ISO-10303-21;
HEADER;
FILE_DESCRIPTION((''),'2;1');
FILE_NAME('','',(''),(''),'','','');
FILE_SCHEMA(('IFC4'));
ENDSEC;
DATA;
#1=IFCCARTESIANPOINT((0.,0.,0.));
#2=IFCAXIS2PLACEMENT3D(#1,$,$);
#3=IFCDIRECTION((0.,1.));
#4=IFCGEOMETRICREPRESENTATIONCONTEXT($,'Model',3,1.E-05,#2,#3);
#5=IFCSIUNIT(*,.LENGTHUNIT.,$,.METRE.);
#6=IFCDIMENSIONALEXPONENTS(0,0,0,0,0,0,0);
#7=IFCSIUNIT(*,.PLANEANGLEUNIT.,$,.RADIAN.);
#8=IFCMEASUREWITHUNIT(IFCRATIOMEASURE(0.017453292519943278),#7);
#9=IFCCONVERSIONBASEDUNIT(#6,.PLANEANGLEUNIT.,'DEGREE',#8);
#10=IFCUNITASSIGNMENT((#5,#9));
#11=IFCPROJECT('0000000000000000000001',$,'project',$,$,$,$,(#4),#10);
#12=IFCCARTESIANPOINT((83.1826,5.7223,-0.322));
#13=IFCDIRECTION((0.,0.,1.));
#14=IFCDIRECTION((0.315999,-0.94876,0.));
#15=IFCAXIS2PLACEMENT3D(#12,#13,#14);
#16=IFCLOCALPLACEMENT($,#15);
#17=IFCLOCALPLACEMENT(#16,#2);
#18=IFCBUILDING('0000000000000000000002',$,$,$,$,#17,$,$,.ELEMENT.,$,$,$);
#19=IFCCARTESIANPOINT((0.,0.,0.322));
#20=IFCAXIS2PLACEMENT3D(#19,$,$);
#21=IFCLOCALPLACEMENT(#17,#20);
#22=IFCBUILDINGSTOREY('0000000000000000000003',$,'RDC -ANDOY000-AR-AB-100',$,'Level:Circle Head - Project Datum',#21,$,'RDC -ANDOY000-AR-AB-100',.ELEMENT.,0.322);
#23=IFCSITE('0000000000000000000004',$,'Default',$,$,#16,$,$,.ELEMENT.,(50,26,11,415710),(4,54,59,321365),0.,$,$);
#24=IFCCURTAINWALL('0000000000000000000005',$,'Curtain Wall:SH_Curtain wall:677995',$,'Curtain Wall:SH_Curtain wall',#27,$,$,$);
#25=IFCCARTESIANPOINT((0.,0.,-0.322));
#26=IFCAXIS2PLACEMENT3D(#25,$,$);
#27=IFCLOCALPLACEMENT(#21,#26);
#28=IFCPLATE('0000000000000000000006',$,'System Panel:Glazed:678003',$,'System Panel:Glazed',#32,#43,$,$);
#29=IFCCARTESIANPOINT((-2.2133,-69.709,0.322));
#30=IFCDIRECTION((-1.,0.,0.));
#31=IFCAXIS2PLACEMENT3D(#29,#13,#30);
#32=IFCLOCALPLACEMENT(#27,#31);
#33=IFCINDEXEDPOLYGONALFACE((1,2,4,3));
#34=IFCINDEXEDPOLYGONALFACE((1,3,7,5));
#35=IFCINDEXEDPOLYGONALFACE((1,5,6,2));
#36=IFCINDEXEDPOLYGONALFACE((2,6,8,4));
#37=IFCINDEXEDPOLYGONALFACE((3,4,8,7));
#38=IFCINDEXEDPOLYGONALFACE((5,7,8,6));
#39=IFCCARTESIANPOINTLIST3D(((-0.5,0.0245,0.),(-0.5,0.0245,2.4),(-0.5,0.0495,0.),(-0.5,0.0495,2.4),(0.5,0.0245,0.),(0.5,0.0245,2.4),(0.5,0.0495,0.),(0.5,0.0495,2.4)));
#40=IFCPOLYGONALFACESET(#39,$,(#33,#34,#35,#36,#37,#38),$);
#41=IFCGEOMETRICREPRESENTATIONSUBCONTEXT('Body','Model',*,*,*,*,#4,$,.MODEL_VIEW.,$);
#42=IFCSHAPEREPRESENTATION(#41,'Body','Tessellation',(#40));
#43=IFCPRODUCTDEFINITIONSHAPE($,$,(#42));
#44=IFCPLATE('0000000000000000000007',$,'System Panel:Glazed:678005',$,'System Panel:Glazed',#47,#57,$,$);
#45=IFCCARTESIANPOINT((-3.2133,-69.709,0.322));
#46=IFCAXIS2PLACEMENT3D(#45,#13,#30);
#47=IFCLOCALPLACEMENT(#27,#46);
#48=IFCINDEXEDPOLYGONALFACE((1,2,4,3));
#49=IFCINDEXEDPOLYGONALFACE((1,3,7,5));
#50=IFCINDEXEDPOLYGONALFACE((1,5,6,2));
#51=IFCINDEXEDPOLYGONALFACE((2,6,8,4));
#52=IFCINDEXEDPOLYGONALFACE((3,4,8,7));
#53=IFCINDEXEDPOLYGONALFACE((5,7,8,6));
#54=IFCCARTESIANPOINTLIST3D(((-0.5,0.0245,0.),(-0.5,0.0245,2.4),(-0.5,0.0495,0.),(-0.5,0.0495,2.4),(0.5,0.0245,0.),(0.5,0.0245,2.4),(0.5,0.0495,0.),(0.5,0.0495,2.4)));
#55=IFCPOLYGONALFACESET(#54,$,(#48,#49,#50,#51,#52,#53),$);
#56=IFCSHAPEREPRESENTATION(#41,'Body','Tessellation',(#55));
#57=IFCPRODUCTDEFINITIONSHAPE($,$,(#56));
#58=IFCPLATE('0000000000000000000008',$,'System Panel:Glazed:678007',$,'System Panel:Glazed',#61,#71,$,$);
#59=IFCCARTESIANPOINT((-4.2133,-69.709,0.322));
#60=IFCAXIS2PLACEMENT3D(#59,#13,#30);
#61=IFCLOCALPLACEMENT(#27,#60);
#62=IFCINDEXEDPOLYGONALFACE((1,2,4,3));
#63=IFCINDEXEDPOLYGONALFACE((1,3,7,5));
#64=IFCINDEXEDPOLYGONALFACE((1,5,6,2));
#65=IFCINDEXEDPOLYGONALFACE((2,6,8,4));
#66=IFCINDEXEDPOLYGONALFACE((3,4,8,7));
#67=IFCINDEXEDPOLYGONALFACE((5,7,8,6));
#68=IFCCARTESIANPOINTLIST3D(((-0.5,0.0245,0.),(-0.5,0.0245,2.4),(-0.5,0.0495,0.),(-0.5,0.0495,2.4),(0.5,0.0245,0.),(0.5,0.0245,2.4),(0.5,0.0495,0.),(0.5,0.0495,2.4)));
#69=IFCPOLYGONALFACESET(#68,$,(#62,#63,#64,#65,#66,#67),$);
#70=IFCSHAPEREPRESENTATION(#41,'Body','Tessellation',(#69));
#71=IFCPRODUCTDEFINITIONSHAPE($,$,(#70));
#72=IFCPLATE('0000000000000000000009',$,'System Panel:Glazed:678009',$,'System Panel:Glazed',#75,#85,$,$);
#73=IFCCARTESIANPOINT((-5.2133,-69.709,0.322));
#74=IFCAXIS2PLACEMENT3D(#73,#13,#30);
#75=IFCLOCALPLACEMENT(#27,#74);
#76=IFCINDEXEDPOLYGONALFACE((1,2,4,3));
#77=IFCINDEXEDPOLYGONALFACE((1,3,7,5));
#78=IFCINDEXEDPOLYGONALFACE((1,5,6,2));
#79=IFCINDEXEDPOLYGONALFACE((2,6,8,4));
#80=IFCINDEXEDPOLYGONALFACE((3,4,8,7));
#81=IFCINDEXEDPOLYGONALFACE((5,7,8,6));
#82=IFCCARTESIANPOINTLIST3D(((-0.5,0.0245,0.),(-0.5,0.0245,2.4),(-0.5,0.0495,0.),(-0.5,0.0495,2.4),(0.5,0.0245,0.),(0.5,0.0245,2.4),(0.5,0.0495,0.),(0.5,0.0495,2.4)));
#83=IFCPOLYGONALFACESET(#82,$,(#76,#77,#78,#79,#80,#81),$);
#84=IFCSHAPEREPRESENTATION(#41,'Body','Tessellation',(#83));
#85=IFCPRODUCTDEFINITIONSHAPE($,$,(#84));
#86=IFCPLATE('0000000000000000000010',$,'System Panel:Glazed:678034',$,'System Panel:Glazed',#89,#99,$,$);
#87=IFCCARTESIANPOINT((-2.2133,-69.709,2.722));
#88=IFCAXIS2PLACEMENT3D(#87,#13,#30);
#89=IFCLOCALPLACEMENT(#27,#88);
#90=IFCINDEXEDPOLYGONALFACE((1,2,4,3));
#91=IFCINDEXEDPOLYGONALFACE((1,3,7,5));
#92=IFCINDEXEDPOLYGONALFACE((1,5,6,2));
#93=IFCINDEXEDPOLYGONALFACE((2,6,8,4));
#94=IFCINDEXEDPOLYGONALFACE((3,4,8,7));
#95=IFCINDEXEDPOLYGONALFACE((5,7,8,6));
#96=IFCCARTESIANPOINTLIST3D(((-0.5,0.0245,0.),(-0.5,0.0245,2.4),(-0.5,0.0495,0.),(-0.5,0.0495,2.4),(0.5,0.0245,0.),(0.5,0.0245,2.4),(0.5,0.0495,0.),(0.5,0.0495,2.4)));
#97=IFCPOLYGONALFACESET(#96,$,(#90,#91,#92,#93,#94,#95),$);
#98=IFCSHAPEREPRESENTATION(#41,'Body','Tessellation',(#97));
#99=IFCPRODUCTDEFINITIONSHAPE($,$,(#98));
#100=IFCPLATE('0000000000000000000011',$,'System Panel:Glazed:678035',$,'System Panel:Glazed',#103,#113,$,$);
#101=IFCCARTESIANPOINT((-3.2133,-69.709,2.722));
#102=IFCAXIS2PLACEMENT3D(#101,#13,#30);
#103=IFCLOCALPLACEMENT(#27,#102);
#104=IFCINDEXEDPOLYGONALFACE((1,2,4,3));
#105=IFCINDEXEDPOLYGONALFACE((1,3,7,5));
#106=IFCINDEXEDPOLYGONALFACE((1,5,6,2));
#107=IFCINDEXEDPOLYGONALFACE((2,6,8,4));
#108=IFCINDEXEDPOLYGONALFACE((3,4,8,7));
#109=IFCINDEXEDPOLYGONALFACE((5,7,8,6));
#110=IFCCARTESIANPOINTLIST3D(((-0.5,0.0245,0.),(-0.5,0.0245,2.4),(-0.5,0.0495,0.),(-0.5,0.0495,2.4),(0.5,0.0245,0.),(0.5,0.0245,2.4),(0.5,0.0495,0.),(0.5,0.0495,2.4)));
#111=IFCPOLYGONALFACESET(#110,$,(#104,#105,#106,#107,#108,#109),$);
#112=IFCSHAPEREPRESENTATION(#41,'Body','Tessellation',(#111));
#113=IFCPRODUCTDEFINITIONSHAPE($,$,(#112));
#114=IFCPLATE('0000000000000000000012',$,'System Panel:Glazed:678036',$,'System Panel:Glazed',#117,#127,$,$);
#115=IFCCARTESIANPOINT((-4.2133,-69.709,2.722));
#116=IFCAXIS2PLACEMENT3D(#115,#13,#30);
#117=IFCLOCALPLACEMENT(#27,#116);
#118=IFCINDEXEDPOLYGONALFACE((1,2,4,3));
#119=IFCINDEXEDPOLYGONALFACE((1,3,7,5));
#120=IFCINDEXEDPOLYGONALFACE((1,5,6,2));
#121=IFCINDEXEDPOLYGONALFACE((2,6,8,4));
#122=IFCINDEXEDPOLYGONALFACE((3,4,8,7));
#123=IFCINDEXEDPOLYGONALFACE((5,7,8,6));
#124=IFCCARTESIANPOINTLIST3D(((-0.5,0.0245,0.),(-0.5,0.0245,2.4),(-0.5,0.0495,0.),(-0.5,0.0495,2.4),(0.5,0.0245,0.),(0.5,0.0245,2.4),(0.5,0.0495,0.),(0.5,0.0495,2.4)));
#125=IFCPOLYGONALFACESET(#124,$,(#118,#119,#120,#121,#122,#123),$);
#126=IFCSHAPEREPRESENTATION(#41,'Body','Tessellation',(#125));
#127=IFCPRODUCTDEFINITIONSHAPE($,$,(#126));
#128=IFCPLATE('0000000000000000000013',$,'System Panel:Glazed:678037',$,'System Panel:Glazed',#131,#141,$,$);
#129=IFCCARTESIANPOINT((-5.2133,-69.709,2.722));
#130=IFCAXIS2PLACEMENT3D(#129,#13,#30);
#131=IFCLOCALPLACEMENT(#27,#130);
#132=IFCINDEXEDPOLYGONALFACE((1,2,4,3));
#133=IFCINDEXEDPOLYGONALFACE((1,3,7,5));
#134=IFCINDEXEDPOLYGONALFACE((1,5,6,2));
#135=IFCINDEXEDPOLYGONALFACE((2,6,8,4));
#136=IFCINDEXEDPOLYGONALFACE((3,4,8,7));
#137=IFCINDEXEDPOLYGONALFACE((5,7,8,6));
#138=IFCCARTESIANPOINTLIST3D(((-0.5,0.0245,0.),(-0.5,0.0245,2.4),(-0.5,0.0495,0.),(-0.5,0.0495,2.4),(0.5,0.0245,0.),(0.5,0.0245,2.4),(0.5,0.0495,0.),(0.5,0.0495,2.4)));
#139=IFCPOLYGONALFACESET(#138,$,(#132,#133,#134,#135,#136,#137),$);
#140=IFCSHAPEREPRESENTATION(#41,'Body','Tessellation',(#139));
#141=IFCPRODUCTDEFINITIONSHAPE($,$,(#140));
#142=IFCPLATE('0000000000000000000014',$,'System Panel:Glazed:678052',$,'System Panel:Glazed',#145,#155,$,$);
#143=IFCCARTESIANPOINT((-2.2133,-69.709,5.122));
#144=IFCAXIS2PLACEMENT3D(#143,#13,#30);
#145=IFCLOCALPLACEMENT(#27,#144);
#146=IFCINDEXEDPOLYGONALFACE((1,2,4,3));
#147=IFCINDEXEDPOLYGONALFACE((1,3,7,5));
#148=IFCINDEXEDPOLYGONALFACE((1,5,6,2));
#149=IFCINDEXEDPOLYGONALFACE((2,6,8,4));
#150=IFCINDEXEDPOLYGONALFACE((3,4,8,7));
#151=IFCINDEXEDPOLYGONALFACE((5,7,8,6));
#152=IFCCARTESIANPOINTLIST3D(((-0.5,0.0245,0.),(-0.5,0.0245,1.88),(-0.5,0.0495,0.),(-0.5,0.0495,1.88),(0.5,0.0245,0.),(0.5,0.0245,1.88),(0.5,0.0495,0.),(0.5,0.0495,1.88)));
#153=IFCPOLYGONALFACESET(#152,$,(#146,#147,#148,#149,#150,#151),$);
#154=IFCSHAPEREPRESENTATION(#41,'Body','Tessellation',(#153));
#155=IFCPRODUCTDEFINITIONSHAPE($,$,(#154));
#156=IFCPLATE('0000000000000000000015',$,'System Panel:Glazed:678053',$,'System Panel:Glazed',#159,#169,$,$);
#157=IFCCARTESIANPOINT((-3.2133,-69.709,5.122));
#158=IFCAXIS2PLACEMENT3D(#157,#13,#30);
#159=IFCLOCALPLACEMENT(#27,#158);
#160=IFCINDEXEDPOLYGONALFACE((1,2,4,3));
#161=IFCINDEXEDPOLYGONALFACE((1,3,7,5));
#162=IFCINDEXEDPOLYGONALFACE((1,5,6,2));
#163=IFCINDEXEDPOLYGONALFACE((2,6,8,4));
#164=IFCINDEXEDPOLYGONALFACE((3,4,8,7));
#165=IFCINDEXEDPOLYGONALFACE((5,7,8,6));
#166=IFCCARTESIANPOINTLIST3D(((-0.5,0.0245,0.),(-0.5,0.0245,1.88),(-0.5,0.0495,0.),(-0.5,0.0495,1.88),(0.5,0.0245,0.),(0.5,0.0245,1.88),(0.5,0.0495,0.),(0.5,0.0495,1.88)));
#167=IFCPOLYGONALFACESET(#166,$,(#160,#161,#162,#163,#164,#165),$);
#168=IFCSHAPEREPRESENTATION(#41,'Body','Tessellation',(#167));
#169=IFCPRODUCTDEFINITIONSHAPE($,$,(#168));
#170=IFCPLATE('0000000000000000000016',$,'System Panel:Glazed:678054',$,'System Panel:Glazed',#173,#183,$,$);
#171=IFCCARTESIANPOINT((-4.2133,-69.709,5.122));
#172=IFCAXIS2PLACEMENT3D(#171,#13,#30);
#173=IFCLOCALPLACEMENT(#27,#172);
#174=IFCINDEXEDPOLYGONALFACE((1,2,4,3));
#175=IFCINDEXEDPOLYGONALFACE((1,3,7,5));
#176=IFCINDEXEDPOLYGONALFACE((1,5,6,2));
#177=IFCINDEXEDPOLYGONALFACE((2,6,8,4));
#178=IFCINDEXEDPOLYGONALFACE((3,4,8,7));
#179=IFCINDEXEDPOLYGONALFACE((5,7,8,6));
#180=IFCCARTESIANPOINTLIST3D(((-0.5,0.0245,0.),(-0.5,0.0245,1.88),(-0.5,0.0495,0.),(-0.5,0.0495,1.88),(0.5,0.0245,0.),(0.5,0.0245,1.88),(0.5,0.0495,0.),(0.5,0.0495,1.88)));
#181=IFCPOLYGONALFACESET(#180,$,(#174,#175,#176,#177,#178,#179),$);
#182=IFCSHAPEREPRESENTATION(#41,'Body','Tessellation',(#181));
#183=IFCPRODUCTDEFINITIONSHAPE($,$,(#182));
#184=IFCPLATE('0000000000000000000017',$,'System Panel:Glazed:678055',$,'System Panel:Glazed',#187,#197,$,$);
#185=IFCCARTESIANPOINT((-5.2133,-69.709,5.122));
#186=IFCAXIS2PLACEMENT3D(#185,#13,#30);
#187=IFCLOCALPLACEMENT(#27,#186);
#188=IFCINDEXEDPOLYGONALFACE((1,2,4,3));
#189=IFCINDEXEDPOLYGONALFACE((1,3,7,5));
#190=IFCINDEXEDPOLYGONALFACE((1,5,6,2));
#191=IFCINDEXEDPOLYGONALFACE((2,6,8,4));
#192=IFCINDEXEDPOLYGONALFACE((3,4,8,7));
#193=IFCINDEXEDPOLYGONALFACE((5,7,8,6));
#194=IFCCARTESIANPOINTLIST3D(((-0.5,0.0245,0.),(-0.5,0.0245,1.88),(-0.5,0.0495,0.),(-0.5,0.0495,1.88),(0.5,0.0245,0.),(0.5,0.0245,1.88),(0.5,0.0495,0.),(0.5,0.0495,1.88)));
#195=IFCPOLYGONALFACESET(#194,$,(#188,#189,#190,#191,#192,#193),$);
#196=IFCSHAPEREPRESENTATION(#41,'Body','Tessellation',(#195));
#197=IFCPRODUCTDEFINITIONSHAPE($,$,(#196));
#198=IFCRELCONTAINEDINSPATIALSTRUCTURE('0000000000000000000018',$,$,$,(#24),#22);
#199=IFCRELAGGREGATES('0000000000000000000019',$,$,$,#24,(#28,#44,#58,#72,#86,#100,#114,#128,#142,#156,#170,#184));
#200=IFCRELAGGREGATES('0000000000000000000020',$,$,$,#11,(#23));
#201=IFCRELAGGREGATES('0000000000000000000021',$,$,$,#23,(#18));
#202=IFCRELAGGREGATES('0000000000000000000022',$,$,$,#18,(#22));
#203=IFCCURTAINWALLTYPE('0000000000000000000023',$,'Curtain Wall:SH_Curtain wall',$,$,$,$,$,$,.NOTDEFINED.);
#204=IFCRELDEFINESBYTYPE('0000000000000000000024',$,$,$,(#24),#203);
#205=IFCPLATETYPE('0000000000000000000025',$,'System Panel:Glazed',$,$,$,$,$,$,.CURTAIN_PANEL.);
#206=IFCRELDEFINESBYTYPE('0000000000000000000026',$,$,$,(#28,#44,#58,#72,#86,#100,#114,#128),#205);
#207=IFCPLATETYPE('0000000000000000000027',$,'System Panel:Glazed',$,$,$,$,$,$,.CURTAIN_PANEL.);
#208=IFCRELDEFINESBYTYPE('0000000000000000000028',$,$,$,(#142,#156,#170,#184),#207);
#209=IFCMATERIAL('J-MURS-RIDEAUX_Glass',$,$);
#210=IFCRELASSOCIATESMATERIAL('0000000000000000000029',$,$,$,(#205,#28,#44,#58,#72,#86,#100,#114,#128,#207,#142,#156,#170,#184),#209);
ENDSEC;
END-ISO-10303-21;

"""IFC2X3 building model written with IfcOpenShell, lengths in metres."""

from ifc_helpers import new_model, entity, si_unit, converted_unit, direction, frame, frame_2d, origin, origin_2d_with_axis, place, context, subcontext, project, spatial, rectangle, extrude, source, transform, mapped, material, type_object, type_shapes, element, aggregate, save


model = new_model("IFC2X3")

# Units and contexts
model_context = context("Model", 3, precision=1e-05, world=origin(), true_north=direction((0.0, 1.0)))
body_context = subcontext(model_context, "Body", "Model", "MODEL_VIEW")
ifc_project = project(units=[si_unit("LENGTHUNIT", "METRE"), converted_unit("PLANEANGLEUNIT", "DEGREE", entity("IfcRatioMeasure", 0.017453292519943278), si_unit("PLANEANGLEUNIT", "RADIAN"), dimensions=[0, 0, 0, 0, 0, 0, 0])], contexts=[model_context])

# Site, building, storey
site_placement = place(None, frame((83.1826, 5.7223, -0.322), z_axis=(0.0, 0.0, 1.0), x_axis=(0.315999, -0.94876, 0.0)))
site = spatial("IfcSite", under=ifc_project, at=site_placement, Name="Default", CompositionType="ELEMENT", RefLatitude=(50, 26, 11, 415710), RefLongitude=(4, 54, 59, 321365), RefElevation=0.0)
building_placement = place(site_placement, origin())
building = spatial("IfcBuilding", under=site, at=building_placement, CompositionType="ELEMENT")
storey_placement = place(building_placement, frame((0.0, 0.0, 0.322)))
storey = spatial("IfcBuildingStorey", under=building, at=storey_placement, Name="RDC -ANDOY000-AR-AB-100", ObjectType="Level:Circle Head - Project Datum", LongName="RDC -ANDOY000-AR-AB-100", CompositionType="ELEMENT", Elevation=0.322)

# Curtain wall, plates
curtain_wall_type = type_object("IfcCurtainWallType", Name="Curtain Wall:SH_Curtain wall", PredefinedType="NOTDEFINED")
curtain_wall_placement = place(storey_placement, frame((0.0, 0.0, -0.322)))
curtain_wall = element("IfcCurtainWall", 1, at=curtain_wall_placement, inside=storey, type_object=curtain_wall_type, Name="Curtain Wall:SH_Curtain wall:677995", ObjectType="Curtain Wall:SH_Curtain wall")
ifc_material_1 = material(Name="J-MURS-RIDEAUX_Glass")
plate_type_1 = type_object("IfcPlateType", Name="System Panel:Glazed", PredefinedType="CURTAIN_PANEL", material=ifc_material_1)
shared_shape_1 = source(origin(), body_context, "Body", "SweptSolid", [
    extrude(rectangle(XDim=0.025, YDim=1.0, at=frame_2d((0.0, 0.0), x_axis=(1.0, 0.0))), frame((0.0, 0.037, 0.0), z_axis=(0.0, 0.0, 1.0), x_axis=(0.0, 1.0, 0.0)), (0.0, 0.0, 1.0), 2.4),
])
type_shapes(plate_type_1, [shared_shape_1])
plate_1_placement = place(curtain_wall_placement, frame((-2.2133, -69.709, 0.322), z_axis=(0.0, 0.0, 1.0), x_axis=(-1.0, 0.0, 0.0)))
plate_1 = element("IfcPlate", 2, at=plate_1_placement, type_object=plate_type_1, material=ifc_material_1, Name="System Panel:Glazed:678003", ObjectType="System Panel:Glazed", context=body_context, shape_type="MappedRepresentation", body=[
    mapped(shared_shape_1, transform((0.0, 0.0, 0.0), scale=1.0)),
])
plate_2_placement = place(curtain_wall_placement, frame((-3.2133, -69.709, 0.322), z_axis=(0.0, 0.0, 1.0), x_axis=(-1.0, 0.0, 0.0)))
plate_2 = element("IfcPlate", 3, at=plate_2_placement, type_object=plate_type_1, material=ifc_material_1, Name="System Panel:Glazed:678005", ObjectType="System Panel:Glazed", context=body_context, shape_type="MappedRepresentation", body=[
    mapped(shared_shape_1, transform((0.0, 0.0, 0.0), scale=1.0)),
])
plate_3_placement = place(curtain_wall_placement, frame((-4.2133, -69.709, 0.322), z_axis=(0.0, 0.0, 1.0), x_axis=(-1.0, 0.0, 0.0)))
plate_3 = element("IfcPlate", 4, at=plate_3_placement, type_object=plate_type_1, material=ifc_material_1, Name="System Panel:Glazed:678007", ObjectType="System Panel:Glazed", context=body_context, shape_type="MappedRepresentation", body=[
    mapped(shared_shape_1, transform((0.0, 0.0, 0.0), scale=1.0)),
])
plate_4_placement = place(curtain_wall_placement, frame((-5.2133, -69.709, 0.322), z_axis=(0.0, 0.0, 1.0), x_axis=(-1.0, 0.0, 0.0)))
plate_4 = element("IfcPlate", 5, at=plate_4_placement, type_object=plate_type_1, material=ifc_material_1, Name="System Panel:Glazed:678009", ObjectType="System Panel:Glazed", context=body_context, shape_type="MappedRepresentation", body=[
    mapped(shared_shape_1, transform((0.0, 0.0, 0.0), scale=1.0)),
])
plate_5_placement = place(curtain_wall_placement, frame((-2.2133, -69.709, 2.722), z_axis=(0.0, 0.0, 1.0), x_axis=(-1.0, 0.0, 0.0)))
plate_5 = element("IfcPlate", 6, at=plate_5_placement, type_object=plate_type_1, material=ifc_material_1, Name="System Panel:Glazed:678034", ObjectType="System Panel:Glazed", context=body_context, shape_type="MappedRepresentation", body=[
    mapped(shared_shape_1, transform((0.0, 0.0, 0.0), scale=1.0)),
])
plate_6_placement = place(curtain_wall_placement, frame((-3.2133, -69.709, 2.722), z_axis=(0.0, 0.0, 1.0), x_axis=(-1.0, 0.0, 0.0)))
plate_6 = element("IfcPlate", 7, at=plate_6_placement, type_object=plate_type_1, material=ifc_material_1, Name="System Panel:Glazed:678035", ObjectType="System Panel:Glazed", context=body_context, shape_type="MappedRepresentation", body=[
    mapped(shared_shape_1, transform((0.0, 0.0, 0.0), scale=1.0)),
])
plate_7_placement = place(curtain_wall_placement, frame((-4.2133, -69.709, 2.722), z_axis=(0.0, 0.0, 1.0), x_axis=(-1.0, 0.0, 0.0)))
plate_7 = element("IfcPlate", 8, at=plate_7_placement, type_object=plate_type_1, material=ifc_material_1, Name="System Panel:Glazed:678036", ObjectType="System Panel:Glazed", context=body_context, shape_type="MappedRepresentation", body=[
    mapped(shared_shape_1, transform((0.0, 0.0, 0.0), scale=1.0)),
])
plate_8_placement = place(curtain_wall_placement, frame((-5.2133, -69.709, 2.722), z_axis=(0.0, 0.0, 1.0), x_axis=(-1.0, 0.0, 0.0)))
plate_8 = element("IfcPlate", 9, at=plate_8_placement, type_object=plate_type_1, material=ifc_material_1, Name="System Panel:Glazed:678037", ObjectType="System Panel:Glazed", context=body_context, shape_type="MappedRepresentation", body=[
    mapped(shared_shape_1, transform((0.0, 0.0, 0.0), scale=1.0)),
])
plate_type_2 = type_object("IfcPlateType", Name="System Panel:Glazed", PredefinedType="CURTAIN_PANEL", material=ifc_material_1)
shared_shape_2 = source(origin(), body_context, "Body", "SweptSolid", [
    extrude(rectangle(XDim=0.025, YDim=1.0, at=origin_2d_with_axis()), frame((0.0, 0.037, 0.0), z_axis=(0.0, 0.0, 1.0), x_axis=(0.0, 1.0, 0.0)), (0.0, 0.0, 1.0), 1.88),
])
type_shapes(plate_type_2, [shared_shape_2])
plate_9_placement = place(curtain_wall_placement, frame((-2.2133, -69.709, 5.122), z_axis=(0.0, 0.0, 1.0), x_axis=(-1.0, 0.0, 0.0)))
plate_9 = element("IfcPlate", 10, at=plate_9_placement, type_object=plate_type_2, material=ifc_material_1, Name="System Panel:Glazed:678052", ObjectType="System Panel:Glazed", context=body_context, shape_type="MappedRepresentation", body=[
    mapped(shared_shape_2, transform((0.0, 0.0, 0.0), scale=1.0)),
])
plate_10_placement = place(curtain_wall_placement, frame((-3.2133, -69.709, 5.122), z_axis=(0.0, 0.0, 1.0), x_axis=(-1.0, 0.0, 0.0)))
plate_10 = element("IfcPlate", 11, at=plate_10_placement, type_object=plate_type_2, material=ifc_material_1, Name="System Panel:Glazed:678053", ObjectType="System Panel:Glazed", context=body_context, shape_type="MappedRepresentation", body=[
    mapped(shared_shape_2, transform((0.0, 0.0, 0.0), scale=1.0)),
])
plate_11_placement = place(curtain_wall_placement, frame((-4.2133, -69.709, 5.122), z_axis=(0.0, 0.0, 1.0), x_axis=(-1.0, 0.0, 0.0)))
plate_11 = element("IfcPlate", 12, at=plate_11_placement, type_object=plate_type_2, material=ifc_material_1, Name="System Panel:Glazed:678054", ObjectType="System Panel:Glazed", context=body_context, shape_type="MappedRepresentation", body=[
    mapped(shared_shape_2, transform((0.0, 0.0, 0.0), scale=1.0)),
])
plate_12_placement = place(curtain_wall_placement, frame((-5.2133, -69.709, 5.122), z_axis=(0.0, 0.0, 1.0), x_axis=(-1.0, 0.0, 0.0)))
plate_12 = element("IfcPlate", 13, at=plate_12_placement, type_object=plate_type_2, material=ifc_material_1, Name="System Panel:Glazed:678055", ObjectType="System Panel:Glazed", context=body_context, shape_type="MappedRepresentation", body=[
    mapped(shared_shape_2, transform((0.0, 0.0, 0.0), scale=1.0)),
])
aggregate(curtain_wall, [plate_1, plate_2, plate_3, plate_4, plate_5, plate_6, plate_7, plate_8, plate_9, plate_10, plate_11, plate_12])

save(model, "model.ifc")
